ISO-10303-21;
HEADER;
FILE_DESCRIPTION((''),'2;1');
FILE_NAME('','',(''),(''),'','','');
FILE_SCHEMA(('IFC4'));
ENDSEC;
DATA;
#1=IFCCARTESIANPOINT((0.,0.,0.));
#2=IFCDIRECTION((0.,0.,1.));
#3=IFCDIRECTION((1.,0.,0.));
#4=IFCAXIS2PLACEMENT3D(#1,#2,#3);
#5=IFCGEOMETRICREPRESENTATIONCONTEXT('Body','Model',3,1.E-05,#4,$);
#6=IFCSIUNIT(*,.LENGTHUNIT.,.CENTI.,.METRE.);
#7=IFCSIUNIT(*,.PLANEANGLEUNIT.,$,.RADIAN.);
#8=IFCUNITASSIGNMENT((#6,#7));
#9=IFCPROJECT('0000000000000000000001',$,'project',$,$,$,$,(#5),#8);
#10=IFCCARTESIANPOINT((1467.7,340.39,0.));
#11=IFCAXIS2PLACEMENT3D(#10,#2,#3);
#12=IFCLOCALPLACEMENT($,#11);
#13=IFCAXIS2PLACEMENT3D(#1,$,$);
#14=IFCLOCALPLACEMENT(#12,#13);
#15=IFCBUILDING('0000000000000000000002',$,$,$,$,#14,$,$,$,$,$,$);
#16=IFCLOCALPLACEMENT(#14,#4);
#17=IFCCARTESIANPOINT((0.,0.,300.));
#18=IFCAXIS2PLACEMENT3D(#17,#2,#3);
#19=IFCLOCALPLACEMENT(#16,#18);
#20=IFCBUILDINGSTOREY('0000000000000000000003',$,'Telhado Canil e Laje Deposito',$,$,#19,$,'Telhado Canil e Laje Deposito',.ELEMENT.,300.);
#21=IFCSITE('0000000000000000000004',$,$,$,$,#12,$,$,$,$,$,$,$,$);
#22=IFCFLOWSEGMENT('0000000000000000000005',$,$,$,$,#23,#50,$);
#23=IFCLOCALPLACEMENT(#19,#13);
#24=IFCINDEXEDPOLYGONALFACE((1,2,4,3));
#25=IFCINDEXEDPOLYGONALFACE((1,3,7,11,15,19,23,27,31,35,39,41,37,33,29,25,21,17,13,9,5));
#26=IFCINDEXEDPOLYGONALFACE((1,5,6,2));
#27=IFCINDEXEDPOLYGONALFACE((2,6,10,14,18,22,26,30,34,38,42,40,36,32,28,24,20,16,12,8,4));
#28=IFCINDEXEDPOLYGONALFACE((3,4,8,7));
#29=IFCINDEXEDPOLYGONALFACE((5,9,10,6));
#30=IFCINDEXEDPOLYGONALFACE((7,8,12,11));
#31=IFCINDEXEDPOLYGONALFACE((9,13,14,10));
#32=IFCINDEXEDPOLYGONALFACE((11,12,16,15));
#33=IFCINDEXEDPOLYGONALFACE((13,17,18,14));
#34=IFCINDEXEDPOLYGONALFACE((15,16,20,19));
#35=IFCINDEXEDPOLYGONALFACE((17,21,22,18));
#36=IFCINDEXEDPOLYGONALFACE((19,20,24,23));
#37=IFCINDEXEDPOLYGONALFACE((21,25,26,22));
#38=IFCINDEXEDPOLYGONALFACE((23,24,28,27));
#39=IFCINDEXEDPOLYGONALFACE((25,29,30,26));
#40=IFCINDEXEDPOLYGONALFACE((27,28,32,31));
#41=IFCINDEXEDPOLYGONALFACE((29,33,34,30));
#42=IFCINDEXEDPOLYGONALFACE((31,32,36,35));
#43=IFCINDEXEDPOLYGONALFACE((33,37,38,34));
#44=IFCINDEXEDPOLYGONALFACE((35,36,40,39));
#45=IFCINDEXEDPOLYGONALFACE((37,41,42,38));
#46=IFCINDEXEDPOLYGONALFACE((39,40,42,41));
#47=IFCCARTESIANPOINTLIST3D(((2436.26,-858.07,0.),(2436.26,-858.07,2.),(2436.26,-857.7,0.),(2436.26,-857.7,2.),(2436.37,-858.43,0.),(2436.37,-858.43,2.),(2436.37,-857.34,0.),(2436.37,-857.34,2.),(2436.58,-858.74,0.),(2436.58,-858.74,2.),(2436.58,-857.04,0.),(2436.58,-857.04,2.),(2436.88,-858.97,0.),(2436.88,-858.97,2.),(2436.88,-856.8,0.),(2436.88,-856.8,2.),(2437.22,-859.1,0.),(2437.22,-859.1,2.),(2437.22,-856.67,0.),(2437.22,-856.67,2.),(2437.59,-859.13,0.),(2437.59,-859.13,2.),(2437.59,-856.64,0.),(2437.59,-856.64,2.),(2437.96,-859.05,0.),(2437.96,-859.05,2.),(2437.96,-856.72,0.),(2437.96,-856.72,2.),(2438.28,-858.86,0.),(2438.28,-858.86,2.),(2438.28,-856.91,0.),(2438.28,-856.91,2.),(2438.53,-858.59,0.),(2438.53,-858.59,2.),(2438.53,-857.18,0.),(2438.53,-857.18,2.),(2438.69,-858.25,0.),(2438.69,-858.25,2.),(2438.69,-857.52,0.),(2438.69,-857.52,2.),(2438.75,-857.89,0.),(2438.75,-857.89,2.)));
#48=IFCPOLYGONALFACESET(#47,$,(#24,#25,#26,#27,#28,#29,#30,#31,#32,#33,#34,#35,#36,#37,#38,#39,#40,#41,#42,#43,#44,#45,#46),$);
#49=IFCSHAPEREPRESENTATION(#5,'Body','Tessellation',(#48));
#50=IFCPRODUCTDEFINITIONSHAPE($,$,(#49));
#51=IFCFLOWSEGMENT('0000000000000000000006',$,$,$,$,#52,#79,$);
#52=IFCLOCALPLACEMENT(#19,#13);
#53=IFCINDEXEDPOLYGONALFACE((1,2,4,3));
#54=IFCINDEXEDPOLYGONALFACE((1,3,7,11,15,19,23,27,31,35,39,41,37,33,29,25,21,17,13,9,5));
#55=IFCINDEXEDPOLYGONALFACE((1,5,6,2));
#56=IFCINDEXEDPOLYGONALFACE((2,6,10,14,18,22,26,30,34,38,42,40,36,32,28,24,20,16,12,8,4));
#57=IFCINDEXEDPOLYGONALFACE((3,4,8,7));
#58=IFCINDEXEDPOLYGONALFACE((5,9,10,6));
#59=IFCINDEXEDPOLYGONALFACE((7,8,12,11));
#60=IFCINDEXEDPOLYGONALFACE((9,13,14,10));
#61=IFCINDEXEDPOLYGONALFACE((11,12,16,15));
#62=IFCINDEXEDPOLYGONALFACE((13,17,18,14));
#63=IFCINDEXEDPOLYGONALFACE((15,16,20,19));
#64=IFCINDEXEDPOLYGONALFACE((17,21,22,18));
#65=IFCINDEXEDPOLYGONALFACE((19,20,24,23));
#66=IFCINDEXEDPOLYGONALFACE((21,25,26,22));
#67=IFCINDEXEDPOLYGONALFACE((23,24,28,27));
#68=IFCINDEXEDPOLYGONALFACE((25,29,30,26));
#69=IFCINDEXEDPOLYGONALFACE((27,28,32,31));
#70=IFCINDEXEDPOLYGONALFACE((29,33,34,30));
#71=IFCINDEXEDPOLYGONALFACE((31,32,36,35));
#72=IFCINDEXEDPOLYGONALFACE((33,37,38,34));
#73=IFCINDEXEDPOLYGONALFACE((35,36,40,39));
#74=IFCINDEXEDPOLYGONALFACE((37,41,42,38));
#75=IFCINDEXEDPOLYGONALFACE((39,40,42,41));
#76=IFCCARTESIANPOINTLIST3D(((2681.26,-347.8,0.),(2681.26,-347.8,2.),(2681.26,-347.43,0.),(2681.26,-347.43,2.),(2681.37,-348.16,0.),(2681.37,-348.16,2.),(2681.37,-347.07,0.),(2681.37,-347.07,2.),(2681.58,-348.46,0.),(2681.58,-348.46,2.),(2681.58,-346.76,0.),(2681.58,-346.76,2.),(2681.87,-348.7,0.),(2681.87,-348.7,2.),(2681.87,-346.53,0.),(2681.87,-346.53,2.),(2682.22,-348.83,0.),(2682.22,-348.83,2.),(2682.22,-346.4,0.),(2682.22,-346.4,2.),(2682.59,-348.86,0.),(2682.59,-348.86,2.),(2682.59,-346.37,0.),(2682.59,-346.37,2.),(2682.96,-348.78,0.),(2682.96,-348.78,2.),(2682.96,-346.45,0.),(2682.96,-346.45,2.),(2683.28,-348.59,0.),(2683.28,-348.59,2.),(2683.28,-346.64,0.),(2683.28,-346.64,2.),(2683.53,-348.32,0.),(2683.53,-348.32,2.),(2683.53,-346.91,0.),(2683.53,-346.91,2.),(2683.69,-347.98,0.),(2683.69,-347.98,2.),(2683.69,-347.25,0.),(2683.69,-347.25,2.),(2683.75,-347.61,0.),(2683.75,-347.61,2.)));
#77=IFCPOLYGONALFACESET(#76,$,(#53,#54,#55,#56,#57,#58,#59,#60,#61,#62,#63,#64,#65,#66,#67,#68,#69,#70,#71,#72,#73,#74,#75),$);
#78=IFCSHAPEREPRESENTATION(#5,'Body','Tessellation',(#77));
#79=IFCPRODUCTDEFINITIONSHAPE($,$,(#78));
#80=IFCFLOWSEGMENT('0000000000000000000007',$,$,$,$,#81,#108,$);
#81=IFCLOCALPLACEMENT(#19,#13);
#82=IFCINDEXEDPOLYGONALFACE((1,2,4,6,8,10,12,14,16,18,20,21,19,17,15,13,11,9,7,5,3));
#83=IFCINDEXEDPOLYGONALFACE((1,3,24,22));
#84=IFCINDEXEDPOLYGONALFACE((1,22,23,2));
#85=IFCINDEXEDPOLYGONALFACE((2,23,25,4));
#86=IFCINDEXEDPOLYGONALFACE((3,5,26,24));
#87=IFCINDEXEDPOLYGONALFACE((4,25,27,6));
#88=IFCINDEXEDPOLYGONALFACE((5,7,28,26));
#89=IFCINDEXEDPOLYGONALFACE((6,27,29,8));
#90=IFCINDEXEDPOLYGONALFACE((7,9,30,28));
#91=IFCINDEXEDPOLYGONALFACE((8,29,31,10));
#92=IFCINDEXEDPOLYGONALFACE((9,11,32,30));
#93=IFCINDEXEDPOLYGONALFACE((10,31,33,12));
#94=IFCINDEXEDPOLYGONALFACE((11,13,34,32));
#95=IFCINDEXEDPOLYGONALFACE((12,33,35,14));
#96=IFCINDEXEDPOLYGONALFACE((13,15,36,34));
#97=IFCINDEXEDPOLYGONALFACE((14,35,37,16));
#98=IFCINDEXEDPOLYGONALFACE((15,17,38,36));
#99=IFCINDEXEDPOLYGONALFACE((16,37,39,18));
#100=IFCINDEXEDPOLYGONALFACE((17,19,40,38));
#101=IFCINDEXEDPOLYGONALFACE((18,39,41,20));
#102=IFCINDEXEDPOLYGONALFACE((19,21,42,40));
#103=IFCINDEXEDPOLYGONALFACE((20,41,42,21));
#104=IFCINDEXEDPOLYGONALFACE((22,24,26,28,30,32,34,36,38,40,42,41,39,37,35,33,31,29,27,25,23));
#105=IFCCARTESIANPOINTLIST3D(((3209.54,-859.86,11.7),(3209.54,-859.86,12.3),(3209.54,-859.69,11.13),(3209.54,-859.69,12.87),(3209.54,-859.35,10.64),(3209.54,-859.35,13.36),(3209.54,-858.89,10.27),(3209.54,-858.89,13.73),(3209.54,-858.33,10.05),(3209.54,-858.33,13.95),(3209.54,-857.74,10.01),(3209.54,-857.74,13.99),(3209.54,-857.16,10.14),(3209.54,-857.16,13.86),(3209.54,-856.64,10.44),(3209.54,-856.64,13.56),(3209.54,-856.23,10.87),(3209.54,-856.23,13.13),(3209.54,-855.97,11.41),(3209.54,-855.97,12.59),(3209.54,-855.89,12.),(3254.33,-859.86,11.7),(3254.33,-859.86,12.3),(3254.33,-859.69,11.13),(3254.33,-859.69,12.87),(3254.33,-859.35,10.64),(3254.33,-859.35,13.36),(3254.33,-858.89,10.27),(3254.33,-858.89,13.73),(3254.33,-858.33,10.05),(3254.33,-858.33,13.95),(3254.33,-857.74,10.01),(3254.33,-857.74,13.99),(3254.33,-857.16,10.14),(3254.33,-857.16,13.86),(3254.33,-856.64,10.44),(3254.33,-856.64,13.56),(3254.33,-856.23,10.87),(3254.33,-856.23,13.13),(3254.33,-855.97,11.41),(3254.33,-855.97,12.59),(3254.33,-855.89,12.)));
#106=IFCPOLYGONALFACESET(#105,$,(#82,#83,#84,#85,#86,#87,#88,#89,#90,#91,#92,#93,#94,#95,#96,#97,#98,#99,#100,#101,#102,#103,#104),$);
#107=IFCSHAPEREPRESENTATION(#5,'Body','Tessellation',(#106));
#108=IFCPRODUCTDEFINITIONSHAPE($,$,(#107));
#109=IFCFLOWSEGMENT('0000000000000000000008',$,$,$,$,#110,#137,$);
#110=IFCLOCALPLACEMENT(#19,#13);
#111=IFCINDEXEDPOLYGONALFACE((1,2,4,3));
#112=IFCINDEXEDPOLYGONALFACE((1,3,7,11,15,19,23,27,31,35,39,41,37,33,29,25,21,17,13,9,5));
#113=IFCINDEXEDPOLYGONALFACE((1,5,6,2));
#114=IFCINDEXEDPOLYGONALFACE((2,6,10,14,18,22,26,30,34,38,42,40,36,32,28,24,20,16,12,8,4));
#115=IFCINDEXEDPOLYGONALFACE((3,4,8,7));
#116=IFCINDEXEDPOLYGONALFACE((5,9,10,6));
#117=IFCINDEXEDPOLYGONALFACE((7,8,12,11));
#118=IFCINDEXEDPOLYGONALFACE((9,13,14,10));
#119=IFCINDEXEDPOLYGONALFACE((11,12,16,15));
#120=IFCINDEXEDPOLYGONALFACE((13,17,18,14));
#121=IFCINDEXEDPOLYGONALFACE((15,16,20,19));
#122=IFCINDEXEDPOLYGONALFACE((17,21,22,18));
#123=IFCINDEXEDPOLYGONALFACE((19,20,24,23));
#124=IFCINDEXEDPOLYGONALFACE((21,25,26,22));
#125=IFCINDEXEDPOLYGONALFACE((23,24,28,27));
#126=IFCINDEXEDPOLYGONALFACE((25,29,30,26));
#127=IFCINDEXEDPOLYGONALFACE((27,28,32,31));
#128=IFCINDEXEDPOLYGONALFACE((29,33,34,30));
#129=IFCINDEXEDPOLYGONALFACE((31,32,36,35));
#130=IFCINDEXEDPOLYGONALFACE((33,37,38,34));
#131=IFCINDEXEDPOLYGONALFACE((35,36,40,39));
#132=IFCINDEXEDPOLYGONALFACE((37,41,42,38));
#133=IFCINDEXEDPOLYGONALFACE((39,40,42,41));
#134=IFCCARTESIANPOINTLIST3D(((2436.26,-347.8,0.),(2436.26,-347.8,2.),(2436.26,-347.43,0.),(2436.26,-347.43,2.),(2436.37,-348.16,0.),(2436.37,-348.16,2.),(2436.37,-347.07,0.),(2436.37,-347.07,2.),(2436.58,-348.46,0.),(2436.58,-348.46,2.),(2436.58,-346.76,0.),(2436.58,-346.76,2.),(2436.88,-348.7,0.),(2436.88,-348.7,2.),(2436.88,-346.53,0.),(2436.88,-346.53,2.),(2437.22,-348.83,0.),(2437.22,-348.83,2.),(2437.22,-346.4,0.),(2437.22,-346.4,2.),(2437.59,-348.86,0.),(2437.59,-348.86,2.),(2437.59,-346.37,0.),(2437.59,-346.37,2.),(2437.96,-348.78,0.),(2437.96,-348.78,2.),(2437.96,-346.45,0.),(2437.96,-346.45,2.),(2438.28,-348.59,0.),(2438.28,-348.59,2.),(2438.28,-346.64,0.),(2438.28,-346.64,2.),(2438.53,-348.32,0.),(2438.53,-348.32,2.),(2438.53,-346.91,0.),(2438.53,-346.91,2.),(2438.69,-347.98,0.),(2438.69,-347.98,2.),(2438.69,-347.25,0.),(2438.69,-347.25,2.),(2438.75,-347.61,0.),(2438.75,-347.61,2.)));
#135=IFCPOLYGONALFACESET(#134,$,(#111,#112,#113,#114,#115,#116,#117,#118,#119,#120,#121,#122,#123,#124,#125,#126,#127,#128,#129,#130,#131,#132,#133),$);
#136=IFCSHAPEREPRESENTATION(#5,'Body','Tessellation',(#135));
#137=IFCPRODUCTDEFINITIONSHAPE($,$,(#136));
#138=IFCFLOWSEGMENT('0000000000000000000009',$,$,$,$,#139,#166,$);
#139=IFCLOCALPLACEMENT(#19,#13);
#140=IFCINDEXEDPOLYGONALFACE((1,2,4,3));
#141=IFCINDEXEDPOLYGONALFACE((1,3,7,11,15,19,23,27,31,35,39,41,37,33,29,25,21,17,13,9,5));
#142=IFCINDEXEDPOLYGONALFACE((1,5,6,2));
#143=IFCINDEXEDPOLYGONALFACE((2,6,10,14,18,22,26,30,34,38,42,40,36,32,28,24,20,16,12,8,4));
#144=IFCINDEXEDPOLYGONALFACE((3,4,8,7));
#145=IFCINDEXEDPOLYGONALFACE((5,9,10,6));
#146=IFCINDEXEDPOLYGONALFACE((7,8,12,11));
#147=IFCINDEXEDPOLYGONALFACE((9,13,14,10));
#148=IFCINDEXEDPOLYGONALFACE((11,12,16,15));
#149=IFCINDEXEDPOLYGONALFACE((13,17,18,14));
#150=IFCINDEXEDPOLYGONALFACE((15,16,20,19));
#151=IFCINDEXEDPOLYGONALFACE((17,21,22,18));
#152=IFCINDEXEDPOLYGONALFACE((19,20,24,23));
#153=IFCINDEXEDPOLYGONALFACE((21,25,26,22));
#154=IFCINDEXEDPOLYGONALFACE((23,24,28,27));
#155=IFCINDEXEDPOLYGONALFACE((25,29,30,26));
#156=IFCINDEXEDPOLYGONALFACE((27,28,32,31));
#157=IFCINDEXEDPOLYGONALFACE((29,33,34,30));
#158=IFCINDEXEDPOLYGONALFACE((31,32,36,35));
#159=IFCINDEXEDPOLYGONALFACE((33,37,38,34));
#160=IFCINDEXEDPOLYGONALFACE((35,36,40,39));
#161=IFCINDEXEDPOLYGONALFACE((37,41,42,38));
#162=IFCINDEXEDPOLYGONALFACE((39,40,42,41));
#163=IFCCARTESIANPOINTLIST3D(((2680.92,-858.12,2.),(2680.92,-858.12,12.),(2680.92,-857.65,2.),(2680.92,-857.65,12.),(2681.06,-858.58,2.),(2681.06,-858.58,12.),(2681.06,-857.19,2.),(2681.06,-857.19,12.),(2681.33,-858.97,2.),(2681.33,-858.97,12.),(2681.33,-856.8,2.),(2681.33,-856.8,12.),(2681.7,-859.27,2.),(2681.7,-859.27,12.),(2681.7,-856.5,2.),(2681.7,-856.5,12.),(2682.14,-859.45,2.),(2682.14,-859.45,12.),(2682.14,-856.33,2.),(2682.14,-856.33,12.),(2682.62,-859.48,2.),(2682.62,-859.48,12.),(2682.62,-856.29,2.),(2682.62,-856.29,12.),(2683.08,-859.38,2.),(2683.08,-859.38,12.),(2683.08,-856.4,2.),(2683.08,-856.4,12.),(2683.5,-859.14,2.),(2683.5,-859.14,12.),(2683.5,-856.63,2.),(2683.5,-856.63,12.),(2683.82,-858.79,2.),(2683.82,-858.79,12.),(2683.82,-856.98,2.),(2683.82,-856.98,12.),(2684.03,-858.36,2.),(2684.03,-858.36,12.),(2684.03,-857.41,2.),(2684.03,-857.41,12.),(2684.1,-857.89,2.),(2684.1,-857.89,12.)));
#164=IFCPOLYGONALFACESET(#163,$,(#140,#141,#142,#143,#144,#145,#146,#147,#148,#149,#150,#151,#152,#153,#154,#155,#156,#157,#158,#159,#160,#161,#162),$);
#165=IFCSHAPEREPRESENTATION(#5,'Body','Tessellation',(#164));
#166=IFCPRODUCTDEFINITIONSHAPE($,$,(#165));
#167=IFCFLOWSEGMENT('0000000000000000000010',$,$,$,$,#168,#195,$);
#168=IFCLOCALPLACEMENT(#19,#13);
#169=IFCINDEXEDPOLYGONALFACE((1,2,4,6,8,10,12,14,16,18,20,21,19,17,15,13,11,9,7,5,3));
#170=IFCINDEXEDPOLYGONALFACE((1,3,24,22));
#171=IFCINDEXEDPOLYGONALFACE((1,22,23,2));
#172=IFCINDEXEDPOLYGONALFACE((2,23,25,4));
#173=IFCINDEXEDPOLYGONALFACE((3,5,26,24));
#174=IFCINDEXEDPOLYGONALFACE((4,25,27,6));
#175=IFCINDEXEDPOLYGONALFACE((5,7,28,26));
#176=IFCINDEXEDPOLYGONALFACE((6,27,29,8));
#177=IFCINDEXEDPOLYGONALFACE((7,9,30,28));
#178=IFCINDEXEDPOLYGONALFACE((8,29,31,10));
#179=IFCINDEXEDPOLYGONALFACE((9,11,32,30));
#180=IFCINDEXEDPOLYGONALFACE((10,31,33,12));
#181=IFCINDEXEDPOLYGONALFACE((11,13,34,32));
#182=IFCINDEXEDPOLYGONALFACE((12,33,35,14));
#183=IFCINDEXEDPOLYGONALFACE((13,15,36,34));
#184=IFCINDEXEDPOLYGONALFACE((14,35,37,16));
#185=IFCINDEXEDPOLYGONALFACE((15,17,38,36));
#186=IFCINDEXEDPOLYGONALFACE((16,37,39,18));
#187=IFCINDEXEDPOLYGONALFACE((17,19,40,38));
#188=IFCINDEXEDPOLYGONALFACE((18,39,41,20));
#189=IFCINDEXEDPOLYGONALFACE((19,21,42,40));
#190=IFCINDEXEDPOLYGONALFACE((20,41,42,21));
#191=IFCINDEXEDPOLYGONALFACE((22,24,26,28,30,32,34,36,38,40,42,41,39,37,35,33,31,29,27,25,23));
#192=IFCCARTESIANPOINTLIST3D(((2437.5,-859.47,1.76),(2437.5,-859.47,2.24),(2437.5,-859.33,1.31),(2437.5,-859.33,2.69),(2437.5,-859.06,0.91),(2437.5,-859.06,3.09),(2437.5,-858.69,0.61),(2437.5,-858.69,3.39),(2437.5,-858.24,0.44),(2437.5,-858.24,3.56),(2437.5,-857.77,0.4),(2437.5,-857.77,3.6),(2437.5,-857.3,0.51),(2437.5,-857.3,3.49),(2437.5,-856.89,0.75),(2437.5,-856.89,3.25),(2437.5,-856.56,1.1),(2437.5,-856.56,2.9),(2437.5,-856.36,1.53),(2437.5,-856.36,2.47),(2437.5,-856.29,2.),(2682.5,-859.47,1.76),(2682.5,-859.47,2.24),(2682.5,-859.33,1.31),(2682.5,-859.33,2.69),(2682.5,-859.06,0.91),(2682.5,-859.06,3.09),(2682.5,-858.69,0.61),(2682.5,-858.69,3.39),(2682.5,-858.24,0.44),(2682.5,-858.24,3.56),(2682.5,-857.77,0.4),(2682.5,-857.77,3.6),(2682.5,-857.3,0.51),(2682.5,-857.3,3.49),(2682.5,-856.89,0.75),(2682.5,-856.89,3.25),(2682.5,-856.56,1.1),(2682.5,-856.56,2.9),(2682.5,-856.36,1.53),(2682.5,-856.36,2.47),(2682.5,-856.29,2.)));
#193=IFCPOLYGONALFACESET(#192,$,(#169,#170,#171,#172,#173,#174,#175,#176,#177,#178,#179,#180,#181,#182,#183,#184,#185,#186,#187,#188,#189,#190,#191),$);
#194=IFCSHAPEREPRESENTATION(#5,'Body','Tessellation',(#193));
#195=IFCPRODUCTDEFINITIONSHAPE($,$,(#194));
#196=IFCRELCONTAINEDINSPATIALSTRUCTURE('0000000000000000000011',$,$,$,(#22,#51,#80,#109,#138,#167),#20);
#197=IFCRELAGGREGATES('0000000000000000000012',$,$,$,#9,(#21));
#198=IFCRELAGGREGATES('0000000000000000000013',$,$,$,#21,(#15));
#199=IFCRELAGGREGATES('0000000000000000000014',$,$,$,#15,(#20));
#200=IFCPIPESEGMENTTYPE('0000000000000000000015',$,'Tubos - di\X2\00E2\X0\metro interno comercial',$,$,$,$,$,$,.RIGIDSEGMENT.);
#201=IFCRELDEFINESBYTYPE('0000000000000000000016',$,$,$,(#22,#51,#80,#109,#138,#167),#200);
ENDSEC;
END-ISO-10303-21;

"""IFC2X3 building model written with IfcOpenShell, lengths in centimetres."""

from ifc_helpers import new_model, si_unit, frame, origin, origin_with_axes, origin_2d_with_axis, place, context, project, spatial, circle, extrude, type_object, element, save


model = new_model("IFC2X3")

# Units and contexts
model_context = context("Model", 3, precision=1e-05, world=origin_with_axes(), identifier="Body")
ifc_project = project(units=[si_unit("LENGTHUNIT", "METRE", prefix="CENTI"), si_unit("PLANEANGLEUNIT", "RADIAN")], contexts=[model_context])

# Site, building, storey
site_placement = place(None, frame((1467.7, 340.39, 0.0), z_axis=(0.0, 0.0, 1.0), x_axis=(1.0, 0.0, 0.0)))
site = spatial("IfcSite", under=ifc_project, at=site_placement)
building_placement = place(site_placement, origin())
building = spatial("IfcBuilding", under=site, at=building_placement)
placement = place(building_placement, origin_with_axes())
storey_placement = place(placement, frame((0.0, 0.0, 300.0), z_axis=(0.0, 0.0, 1.0), x_axis=(1.0, 0.0, 0.0)))
storey = spatial("IfcBuildingStorey", under=building, at=storey_placement, Name="Telhado Canil e Laje Deposito", LongName="Telhado Canil e Laje Deposito", CompositionType="ELEMENT", Elevation=300.0)

# Flow segments
pipe_segment_type = type_object("IfcPipeSegmentType", Name="Tubos - diâmetro interno comercial", PredefinedType="RIGIDSEGMENT")
for number, where, z_axis, x_axis in (
    (1, (2437.5, -857.89, 2.0), (0.0, 0.0, 1.0), (1.0, 0.0, 0.0)),
    (2, (2682.5, -347.61, 2.0), (0.0, 0.0, 1.0), (1.0, 0.0, 0.0)),
):
    element("IfcFlowSegment", number, at=place(storey_placement, frame(where, z_axis=z_axis, x_axis=x_axis)), inside=storey, type_object=pipe_segment_type, context=model_context, shape_type="SolidModel", body=[
        extrude(circle(Radius=1.25, at=origin_2d_with_axis()), frame((0.0, 0.0, 0.0), z_axis=(0.0, 0.0, -1.0), x_axis=(1.0, 0.0, 0.0)), (0.0, 0.0, 1.0), 2.0),
    ])
flow_segment_1_placement = place(storey_placement, frame((3231.93, -857.89, 14.0), z_axis=(0.0, 0.0, 1.0), x_axis=(1.0, 0.0, 0.0)))
element("IfcFlowSegment", 3, at=flow_segment_1_placement, inside=storey, type_object=pipe_segment_type, context=model_context, shape_type="SolidModel", body=[
    extrude(circle(Radius=2.0, at=origin_2d_with_axis()), frame((-22.39, 0.0, -2.0), z_axis=(1.0, 0.0, 0.0), x_axis=(0.0, 1.0, 0.0)), (0.0, 0.0, 1.0), 44.78),
])
flow_segment_2_placement = place(storey_placement, frame((2437.5, -347.61, 2.0), z_axis=(0.0, 0.0, 1.0), x_axis=(1.0, 0.0, 0.0)))
element("IfcFlowSegment", 4, at=flow_segment_2_placement, inside=storey, type_object=pipe_segment_type, context=model_context, shape_type="SolidModel", body=[
    extrude(circle(Radius=1.25, at=origin_2d_with_axis()), frame((0.0, 0.0, 0.0), z_axis=(0.0, 0.0, -1.0), x_axis=(1.0, 0.0, 0.0)), (0.0, 0.0, 1.0), 2.0),
])
flow_segment_3_placement = place(storey_placement, frame((2682.5, -857.89, 12.0), z_axis=(0.0, 0.0, 1.0), x_axis=(1.0, 0.0, 0.0)))
element("IfcFlowSegment", 5, at=flow_segment_3_placement, inside=storey, type_object=pipe_segment_type, context=model_context, shape_type="SolidModel", body=[
    extrude(circle(Radius=1.6, at=origin_2d_with_axis()), frame((0.0, 0.0, 0.0), z_axis=(0.0, 0.0, -1.0), x_axis=(1.0, 0.0, 0.0)), (0.0, 0.0, 1.0), 10.0),
])
flow_segment_4_placement = place(storey_placement, frame((2560.0, -857.89, 3.6), z_axis=(0.0, 0.0, 1.0), x_axis=(1.0, 0.0, 0.0)))
element("IfcFlowSegment", 6, at=flow_segment_4_placement, inside=storey, type_object=pipe_segment_type, context=model_context, shape_type="SolidModel", body=[
    extrude(circle(Radius=1.6, at=origin_2d_with_axis()), frame((122.5, 0.0, -1.6), z_axis=(-1.0, 0.0, 0.0), x_axis=(0.0, 1.0, 0.0)), (0.0, 0.0, 1.0), 245.0),
])

save(model, "model.ifc")
